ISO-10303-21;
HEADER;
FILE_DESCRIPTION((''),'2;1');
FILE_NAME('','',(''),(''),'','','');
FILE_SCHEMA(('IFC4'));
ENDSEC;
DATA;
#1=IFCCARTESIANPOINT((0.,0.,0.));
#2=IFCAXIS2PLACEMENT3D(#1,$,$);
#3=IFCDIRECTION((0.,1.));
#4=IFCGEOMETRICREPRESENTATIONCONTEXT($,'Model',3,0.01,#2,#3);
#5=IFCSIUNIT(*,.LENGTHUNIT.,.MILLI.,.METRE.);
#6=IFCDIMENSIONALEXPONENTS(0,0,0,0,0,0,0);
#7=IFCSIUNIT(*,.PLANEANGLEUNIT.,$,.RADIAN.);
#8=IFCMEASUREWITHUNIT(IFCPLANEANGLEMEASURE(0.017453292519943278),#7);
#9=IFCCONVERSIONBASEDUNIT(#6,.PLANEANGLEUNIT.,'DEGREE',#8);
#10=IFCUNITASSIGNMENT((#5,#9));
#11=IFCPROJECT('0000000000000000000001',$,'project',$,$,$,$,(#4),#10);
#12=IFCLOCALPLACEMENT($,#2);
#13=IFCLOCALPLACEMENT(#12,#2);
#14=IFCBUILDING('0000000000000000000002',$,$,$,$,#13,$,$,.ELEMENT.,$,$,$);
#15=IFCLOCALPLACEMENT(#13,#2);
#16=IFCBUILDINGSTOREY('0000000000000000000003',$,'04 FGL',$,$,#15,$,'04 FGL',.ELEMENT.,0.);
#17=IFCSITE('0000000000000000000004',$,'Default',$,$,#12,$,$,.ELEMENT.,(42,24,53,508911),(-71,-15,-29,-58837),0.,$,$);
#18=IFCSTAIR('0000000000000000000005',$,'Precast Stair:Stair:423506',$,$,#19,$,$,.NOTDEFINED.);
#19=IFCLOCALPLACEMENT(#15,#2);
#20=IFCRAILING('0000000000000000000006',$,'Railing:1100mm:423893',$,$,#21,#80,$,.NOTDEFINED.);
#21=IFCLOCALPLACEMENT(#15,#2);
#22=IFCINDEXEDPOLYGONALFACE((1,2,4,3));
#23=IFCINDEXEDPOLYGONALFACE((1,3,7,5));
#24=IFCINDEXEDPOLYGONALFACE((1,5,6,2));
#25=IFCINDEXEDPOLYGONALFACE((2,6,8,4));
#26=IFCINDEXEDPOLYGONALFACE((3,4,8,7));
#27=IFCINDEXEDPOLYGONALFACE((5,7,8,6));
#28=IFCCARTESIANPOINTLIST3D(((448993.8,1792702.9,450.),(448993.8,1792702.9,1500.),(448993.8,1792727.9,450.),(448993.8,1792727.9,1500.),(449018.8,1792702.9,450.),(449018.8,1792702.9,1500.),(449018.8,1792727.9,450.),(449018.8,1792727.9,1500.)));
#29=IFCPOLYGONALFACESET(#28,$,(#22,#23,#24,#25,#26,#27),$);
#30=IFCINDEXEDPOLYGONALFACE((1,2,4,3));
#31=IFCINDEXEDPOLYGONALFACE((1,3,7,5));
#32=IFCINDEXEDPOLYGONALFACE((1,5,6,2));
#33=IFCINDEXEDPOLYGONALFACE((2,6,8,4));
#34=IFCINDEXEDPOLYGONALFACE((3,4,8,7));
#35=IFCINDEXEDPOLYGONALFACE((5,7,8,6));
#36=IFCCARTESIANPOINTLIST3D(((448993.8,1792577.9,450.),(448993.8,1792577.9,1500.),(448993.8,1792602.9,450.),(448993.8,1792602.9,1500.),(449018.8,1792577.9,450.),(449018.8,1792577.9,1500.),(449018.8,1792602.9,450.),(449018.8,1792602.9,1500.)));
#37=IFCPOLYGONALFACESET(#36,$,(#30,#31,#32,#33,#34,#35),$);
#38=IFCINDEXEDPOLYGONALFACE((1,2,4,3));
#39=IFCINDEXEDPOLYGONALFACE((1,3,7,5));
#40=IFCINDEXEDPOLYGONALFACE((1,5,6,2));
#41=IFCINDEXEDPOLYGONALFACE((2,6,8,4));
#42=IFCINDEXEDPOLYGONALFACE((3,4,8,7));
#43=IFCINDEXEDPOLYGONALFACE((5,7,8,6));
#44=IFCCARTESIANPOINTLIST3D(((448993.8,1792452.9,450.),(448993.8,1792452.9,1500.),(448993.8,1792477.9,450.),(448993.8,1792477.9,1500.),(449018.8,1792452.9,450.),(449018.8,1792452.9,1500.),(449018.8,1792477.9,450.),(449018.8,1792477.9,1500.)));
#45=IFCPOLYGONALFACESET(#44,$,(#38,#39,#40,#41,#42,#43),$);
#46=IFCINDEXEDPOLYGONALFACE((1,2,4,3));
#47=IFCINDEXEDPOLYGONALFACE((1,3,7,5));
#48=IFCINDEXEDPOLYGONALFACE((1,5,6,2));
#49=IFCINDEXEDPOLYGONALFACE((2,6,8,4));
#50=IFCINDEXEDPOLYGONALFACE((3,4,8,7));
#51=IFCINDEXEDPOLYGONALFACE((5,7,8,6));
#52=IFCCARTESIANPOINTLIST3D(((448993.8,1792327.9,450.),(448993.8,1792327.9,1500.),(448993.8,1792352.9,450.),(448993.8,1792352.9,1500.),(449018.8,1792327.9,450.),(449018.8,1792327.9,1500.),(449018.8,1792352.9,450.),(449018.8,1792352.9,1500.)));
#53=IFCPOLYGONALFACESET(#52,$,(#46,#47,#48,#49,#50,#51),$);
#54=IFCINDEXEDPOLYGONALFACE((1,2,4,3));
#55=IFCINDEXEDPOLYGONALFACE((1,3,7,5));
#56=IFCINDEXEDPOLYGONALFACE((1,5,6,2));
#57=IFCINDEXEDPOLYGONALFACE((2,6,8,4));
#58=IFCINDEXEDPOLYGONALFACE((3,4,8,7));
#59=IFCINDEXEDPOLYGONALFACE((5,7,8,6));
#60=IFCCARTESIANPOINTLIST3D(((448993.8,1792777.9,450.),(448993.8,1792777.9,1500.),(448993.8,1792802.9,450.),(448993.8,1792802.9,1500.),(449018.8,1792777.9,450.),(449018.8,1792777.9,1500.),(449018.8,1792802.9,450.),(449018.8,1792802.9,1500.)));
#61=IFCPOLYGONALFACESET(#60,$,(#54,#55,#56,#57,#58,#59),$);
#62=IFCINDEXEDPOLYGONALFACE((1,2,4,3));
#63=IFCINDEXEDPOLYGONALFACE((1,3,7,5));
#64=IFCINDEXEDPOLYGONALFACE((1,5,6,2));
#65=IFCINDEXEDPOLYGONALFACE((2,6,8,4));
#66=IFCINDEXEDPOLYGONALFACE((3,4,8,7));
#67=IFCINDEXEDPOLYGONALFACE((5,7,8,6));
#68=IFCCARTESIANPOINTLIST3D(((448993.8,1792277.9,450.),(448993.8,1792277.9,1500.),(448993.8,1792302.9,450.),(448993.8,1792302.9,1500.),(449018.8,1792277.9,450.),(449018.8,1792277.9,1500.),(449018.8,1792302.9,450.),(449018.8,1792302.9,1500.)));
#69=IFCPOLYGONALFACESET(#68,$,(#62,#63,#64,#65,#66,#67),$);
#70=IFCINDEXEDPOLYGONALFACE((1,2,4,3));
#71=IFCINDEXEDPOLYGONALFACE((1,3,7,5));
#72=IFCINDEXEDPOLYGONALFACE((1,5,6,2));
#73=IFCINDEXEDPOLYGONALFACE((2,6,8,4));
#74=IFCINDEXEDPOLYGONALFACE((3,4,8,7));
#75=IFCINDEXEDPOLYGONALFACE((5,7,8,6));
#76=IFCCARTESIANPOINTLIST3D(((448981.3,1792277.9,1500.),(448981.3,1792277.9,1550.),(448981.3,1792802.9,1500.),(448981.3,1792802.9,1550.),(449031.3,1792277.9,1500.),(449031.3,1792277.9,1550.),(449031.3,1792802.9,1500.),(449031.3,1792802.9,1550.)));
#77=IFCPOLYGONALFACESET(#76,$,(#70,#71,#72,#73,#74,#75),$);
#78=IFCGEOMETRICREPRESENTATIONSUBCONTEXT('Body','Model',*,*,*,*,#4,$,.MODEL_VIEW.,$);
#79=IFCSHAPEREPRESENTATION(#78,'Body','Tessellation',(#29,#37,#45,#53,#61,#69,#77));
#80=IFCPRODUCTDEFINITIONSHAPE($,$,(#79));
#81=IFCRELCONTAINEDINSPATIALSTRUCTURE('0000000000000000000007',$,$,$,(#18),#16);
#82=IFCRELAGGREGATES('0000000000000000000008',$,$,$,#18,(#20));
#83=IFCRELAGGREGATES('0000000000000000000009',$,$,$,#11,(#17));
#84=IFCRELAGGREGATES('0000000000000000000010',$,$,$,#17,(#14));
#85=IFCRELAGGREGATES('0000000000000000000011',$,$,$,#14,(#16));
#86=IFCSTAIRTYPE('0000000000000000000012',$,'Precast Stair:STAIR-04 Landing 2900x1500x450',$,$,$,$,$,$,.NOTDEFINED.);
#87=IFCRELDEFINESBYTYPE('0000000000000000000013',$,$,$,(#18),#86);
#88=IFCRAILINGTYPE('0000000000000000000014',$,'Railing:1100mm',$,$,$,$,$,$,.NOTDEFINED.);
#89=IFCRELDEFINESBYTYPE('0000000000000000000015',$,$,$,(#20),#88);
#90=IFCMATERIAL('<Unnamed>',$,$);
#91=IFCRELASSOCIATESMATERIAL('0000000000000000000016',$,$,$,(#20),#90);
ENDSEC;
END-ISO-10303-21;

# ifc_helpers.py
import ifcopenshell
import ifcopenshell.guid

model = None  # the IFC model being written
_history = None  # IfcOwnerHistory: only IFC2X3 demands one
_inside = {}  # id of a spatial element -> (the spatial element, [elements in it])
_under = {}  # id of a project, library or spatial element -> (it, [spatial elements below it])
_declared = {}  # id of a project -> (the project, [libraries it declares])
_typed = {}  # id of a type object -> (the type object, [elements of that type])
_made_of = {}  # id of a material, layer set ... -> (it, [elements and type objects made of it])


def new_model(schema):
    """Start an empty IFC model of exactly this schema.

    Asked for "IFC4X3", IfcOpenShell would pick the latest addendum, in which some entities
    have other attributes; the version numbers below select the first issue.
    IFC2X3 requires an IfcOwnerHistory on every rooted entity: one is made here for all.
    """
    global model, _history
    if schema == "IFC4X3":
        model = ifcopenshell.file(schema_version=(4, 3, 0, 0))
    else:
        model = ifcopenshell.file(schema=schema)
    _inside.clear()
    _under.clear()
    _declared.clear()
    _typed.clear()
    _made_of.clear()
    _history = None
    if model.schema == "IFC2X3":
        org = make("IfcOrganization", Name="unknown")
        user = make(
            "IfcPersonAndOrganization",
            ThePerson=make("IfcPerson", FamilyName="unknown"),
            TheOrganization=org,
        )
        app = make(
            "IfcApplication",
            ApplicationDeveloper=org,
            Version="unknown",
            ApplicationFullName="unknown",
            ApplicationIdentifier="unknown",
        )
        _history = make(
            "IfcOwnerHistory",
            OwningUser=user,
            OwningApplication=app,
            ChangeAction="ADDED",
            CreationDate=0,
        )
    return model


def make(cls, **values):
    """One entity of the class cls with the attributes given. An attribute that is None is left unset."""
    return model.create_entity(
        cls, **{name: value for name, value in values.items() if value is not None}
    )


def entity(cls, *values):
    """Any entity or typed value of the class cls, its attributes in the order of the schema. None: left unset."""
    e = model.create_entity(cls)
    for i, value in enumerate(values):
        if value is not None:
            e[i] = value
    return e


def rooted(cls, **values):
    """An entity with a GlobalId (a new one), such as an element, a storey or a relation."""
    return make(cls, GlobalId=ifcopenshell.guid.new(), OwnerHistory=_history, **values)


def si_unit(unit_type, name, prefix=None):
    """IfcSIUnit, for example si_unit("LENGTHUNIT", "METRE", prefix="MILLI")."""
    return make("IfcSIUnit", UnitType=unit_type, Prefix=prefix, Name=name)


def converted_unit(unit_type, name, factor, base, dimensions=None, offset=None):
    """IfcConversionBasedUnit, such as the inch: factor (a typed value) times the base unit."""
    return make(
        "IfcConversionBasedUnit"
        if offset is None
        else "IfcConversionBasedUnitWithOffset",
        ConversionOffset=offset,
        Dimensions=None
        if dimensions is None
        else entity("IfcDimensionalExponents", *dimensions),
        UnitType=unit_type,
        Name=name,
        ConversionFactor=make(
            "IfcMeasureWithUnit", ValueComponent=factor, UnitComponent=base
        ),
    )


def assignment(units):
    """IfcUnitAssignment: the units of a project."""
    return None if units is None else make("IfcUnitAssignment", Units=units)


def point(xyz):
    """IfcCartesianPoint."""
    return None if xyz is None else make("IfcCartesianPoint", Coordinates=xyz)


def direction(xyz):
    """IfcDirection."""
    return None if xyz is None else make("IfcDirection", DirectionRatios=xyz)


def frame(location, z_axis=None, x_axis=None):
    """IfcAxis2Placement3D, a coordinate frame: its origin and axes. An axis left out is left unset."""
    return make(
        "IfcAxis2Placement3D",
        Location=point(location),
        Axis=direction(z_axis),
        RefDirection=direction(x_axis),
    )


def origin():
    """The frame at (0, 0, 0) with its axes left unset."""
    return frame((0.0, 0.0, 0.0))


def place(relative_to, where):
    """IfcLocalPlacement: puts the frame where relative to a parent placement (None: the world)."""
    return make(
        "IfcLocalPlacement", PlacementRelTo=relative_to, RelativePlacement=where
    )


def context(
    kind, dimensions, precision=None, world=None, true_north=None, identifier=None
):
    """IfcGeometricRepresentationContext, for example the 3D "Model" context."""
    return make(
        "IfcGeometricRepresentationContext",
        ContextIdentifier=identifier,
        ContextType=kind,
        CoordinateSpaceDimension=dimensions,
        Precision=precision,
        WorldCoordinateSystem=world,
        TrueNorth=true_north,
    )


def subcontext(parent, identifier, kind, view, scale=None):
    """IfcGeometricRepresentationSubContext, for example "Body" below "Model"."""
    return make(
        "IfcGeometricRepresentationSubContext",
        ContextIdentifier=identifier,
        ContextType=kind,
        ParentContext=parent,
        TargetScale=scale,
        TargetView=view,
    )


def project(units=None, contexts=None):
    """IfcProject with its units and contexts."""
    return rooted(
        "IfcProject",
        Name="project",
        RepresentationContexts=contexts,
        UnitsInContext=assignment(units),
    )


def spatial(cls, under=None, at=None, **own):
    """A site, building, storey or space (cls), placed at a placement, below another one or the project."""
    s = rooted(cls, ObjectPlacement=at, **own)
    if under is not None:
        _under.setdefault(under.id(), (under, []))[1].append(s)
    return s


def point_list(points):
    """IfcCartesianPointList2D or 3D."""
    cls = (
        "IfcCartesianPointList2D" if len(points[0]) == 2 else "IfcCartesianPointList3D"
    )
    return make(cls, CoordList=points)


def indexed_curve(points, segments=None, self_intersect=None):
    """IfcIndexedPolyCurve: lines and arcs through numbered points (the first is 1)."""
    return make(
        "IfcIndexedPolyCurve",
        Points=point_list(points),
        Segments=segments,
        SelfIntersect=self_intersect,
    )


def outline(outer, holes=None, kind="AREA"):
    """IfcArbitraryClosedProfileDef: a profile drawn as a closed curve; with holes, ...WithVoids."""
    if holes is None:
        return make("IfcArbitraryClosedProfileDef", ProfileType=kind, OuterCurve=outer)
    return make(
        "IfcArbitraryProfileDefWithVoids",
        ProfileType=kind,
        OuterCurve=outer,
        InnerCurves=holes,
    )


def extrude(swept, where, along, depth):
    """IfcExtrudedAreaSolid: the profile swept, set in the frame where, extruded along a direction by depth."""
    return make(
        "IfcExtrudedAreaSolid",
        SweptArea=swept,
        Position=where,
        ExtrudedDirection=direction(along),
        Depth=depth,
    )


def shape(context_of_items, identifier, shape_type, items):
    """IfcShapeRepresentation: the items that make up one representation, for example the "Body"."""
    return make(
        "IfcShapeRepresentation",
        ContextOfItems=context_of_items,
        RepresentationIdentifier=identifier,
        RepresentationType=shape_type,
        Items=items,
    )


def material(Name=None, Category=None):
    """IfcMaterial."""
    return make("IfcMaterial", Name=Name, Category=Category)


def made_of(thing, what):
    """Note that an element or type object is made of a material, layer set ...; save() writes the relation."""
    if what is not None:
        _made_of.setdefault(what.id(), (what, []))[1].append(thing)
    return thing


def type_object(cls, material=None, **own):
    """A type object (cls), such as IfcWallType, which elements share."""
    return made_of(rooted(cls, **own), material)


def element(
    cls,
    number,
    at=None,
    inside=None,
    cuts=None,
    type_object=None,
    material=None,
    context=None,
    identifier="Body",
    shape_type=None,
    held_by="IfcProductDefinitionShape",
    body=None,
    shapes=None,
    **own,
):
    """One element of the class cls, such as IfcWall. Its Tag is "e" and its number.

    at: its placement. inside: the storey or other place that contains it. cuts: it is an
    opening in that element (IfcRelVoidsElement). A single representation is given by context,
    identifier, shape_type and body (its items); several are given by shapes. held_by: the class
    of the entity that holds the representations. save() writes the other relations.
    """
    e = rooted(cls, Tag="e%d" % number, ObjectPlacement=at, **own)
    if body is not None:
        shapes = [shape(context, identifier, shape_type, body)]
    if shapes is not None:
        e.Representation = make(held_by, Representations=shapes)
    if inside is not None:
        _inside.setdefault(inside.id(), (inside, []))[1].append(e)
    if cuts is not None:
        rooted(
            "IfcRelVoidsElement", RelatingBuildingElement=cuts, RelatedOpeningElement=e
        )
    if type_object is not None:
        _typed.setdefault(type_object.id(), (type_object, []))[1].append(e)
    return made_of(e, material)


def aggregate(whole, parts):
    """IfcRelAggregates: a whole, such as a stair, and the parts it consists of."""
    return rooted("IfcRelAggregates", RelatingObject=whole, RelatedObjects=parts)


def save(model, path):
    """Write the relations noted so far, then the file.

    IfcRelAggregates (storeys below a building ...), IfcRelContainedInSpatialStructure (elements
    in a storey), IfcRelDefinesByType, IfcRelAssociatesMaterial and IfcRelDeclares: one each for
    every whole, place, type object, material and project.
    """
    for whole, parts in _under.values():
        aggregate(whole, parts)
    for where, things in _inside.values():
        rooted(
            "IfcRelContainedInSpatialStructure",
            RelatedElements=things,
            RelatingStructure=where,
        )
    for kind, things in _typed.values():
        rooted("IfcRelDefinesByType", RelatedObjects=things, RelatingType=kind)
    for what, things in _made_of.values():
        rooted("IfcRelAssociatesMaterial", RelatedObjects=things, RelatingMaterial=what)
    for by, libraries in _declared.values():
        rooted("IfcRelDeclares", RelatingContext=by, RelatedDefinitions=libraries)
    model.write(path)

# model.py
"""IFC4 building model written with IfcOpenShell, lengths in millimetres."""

from ifc_helpers import new_model, entity, si_unit, converted_unit, direction, frame, origin, place, context, subcontext, project, spatial, indexed_curve, outline, extrude, material, type_object, element, aggregate, save


model = new_model("IFC4")

# Units and contexts
model_context = context("Model", 3, precision=0.01, world=origin(), true_north=direction((0.0, 1.0)))
body_context = subcontext(model_context, "Body", "Model", "MODEL_VIEW")
ifc_project = project(units=[si_unit("LENGTHUNIT", "METRE", prefix="MILLI"), converted_unit("PLANEANGLEUNIT", "DEGREE", entity("IfcPlaneAngleMeasure", 0.017453292519943278), si_unit("PLANEANGLEUNIT", "RADIAN"), dimensions=[0, 0, 0, 0, 0, 0, 0])], contexts=[model_context])

# Site, building, storey
site_placement = place(None, origin())
site = spatial("IfcSite", under=ifc_project, at=site_placement, Name="Default", CompositionType="ELEMENT", RefLatitude=(42, 24, 53, 508911), RefLongitude=(-71, -15, -29, -58837), RefElevation=0.0)
building_placement = place(site_placement, origin())
building = spatial("IfcBuilding", under=site, at=building_placement, CompositionType="ELEMENT")
storey_placement = place(building_placement, origin())
storey = spatial("IfcBuildingStorey", under=building, at=storey_placement, Name="04 FGL", LongName="04 FGL", CompositionType="ELEMENT", Elevation=0.0)

# Stair, railing
stair_type = type_object("IfcStairType", Name="Precast Stair:STAIR-04 Landing 2900x1500x450", PredefinedType="NOTDEFINED")
stair_placement = place(storey_placement, origin())
stair = element("IfcStair", 1, at=stair_placement, inside=storey, type_object=stair_type, Name="Precast Stair:Stair:423506", PredefinedType="NOTDEFINED")
ifc_material_1 = material(Name="<Unnamed>")
railing_type = type_object("IfcRailingType", Name="Railing:1100mm", PredefinedType="NOTDEFINED")
railing_1_placement = place(stair_placement, frame((0.0, 0.0, 450.0)))
railing_1 = element("IfcRailing", 2, at=railing_1_placement, type_object=railing_type, material=ifc_material_1, Name="Railing:1100mm:423893", PredefinedType="NOTDEFINED", context=body_context, shape_type="SweptSolid", body=[
    extrude(outline(indexed_curve([(-12.5, -12.5), (12.5, -12.5), (12.5, 12.5), (-12.5, 12.5), (-12.5, -12.5)], self_intersect=False)), frame((449006.3, 1792715.4, 0.0), z_axis=(0.0, 0.0, 1.0), x_axis=(0.0, 1.0, 0.0)), (0.0, 0.0, 1.0), 1050.0),
    extrude(outline(indexed_curve([(-12.5, -12.5), (12.5, -12.5), (12.5, 12.5), (-12.5, 12.5), (-12.5, -12.5)], self_intersect=False)), frame((449006.3, 1792590.4, 0.0), z_axis=(0.0, 0.0, 1.0), x_axis=(0.0, 1.0, 0.0)), (0.0, 0.0, 1.0), 1050.0),
    extrude(outline(indexed_curve([(-12.5, -12.5), (12.5, -12.5), (12.5, 12.5), (-12.5, 12.5), (-12.5, -12.5)], self_intersect=False)), frame((449006.3, 1792465.4, 0.0), z_axis=(0.0, 0.0, 1.0), x_axis=(0.0, 1.0, 0.0)), (0.0, 0.0, 1.0), 1050.0),
    extrude(outline(indexed_curve([(-12.5, -12.5), (12.5, -12.5), (12.5, 12.5), (-12.5, 12.5), (-12.5, -12.5)], self_intersect=False)), frame((449006.3, 1792340.4, 0.0), z_axis=(0.0, 0.0, 1.0), x_axis=(0.0, 1.0, 0.0)), (0.0, 0.0, 1.0), 1050.0),
    extrude(outline(indexed_curve([(-12.5, -12.5), (12.5, -12.5), (12.5, 12.5), (-12.5, 12.5), (-12.5, -12.5)], self_intersect=False)), frame((449006.3, 1792790.4, 0.0), z_axis=(0.0, 0.0, 1.0), x_axis=(0.0, 1.0, 0.0)), (0.0, 0.0, 1.0), 1050.0),
    extrude(outline(indexed_curve([(-12.5, -12.5), (12.5, -12.5), (12.5, 12.5), (-12.5, 12.5), (-12.5, -12.5)], self_intersect=False)), frame((449006.3, 1792290.4, 0.0), z_axis=(0.0, 0.0, 1.0), x_axis=(0.0, 1.0, 0.0)), (0.0, 0.0, 1.0), 1050.0),
    extrude(outline(indexed_curve([(-262.5, -25.0), (262.5, -25.0), (262.5, 25.0), (-262.5, 25.0), (-262.5, -25.0)], self_intersect=False)), frame((449006.3, 1792540.4, 1050.0), z_axis=(0.0, 0.0, 1.0), x_axis=(0.0, 1.0, 0.0)), (0.0, 0.0, 1.0), 50.0),
])
aggregate(stair, [railing_1])

save(model, "model.ifc")
